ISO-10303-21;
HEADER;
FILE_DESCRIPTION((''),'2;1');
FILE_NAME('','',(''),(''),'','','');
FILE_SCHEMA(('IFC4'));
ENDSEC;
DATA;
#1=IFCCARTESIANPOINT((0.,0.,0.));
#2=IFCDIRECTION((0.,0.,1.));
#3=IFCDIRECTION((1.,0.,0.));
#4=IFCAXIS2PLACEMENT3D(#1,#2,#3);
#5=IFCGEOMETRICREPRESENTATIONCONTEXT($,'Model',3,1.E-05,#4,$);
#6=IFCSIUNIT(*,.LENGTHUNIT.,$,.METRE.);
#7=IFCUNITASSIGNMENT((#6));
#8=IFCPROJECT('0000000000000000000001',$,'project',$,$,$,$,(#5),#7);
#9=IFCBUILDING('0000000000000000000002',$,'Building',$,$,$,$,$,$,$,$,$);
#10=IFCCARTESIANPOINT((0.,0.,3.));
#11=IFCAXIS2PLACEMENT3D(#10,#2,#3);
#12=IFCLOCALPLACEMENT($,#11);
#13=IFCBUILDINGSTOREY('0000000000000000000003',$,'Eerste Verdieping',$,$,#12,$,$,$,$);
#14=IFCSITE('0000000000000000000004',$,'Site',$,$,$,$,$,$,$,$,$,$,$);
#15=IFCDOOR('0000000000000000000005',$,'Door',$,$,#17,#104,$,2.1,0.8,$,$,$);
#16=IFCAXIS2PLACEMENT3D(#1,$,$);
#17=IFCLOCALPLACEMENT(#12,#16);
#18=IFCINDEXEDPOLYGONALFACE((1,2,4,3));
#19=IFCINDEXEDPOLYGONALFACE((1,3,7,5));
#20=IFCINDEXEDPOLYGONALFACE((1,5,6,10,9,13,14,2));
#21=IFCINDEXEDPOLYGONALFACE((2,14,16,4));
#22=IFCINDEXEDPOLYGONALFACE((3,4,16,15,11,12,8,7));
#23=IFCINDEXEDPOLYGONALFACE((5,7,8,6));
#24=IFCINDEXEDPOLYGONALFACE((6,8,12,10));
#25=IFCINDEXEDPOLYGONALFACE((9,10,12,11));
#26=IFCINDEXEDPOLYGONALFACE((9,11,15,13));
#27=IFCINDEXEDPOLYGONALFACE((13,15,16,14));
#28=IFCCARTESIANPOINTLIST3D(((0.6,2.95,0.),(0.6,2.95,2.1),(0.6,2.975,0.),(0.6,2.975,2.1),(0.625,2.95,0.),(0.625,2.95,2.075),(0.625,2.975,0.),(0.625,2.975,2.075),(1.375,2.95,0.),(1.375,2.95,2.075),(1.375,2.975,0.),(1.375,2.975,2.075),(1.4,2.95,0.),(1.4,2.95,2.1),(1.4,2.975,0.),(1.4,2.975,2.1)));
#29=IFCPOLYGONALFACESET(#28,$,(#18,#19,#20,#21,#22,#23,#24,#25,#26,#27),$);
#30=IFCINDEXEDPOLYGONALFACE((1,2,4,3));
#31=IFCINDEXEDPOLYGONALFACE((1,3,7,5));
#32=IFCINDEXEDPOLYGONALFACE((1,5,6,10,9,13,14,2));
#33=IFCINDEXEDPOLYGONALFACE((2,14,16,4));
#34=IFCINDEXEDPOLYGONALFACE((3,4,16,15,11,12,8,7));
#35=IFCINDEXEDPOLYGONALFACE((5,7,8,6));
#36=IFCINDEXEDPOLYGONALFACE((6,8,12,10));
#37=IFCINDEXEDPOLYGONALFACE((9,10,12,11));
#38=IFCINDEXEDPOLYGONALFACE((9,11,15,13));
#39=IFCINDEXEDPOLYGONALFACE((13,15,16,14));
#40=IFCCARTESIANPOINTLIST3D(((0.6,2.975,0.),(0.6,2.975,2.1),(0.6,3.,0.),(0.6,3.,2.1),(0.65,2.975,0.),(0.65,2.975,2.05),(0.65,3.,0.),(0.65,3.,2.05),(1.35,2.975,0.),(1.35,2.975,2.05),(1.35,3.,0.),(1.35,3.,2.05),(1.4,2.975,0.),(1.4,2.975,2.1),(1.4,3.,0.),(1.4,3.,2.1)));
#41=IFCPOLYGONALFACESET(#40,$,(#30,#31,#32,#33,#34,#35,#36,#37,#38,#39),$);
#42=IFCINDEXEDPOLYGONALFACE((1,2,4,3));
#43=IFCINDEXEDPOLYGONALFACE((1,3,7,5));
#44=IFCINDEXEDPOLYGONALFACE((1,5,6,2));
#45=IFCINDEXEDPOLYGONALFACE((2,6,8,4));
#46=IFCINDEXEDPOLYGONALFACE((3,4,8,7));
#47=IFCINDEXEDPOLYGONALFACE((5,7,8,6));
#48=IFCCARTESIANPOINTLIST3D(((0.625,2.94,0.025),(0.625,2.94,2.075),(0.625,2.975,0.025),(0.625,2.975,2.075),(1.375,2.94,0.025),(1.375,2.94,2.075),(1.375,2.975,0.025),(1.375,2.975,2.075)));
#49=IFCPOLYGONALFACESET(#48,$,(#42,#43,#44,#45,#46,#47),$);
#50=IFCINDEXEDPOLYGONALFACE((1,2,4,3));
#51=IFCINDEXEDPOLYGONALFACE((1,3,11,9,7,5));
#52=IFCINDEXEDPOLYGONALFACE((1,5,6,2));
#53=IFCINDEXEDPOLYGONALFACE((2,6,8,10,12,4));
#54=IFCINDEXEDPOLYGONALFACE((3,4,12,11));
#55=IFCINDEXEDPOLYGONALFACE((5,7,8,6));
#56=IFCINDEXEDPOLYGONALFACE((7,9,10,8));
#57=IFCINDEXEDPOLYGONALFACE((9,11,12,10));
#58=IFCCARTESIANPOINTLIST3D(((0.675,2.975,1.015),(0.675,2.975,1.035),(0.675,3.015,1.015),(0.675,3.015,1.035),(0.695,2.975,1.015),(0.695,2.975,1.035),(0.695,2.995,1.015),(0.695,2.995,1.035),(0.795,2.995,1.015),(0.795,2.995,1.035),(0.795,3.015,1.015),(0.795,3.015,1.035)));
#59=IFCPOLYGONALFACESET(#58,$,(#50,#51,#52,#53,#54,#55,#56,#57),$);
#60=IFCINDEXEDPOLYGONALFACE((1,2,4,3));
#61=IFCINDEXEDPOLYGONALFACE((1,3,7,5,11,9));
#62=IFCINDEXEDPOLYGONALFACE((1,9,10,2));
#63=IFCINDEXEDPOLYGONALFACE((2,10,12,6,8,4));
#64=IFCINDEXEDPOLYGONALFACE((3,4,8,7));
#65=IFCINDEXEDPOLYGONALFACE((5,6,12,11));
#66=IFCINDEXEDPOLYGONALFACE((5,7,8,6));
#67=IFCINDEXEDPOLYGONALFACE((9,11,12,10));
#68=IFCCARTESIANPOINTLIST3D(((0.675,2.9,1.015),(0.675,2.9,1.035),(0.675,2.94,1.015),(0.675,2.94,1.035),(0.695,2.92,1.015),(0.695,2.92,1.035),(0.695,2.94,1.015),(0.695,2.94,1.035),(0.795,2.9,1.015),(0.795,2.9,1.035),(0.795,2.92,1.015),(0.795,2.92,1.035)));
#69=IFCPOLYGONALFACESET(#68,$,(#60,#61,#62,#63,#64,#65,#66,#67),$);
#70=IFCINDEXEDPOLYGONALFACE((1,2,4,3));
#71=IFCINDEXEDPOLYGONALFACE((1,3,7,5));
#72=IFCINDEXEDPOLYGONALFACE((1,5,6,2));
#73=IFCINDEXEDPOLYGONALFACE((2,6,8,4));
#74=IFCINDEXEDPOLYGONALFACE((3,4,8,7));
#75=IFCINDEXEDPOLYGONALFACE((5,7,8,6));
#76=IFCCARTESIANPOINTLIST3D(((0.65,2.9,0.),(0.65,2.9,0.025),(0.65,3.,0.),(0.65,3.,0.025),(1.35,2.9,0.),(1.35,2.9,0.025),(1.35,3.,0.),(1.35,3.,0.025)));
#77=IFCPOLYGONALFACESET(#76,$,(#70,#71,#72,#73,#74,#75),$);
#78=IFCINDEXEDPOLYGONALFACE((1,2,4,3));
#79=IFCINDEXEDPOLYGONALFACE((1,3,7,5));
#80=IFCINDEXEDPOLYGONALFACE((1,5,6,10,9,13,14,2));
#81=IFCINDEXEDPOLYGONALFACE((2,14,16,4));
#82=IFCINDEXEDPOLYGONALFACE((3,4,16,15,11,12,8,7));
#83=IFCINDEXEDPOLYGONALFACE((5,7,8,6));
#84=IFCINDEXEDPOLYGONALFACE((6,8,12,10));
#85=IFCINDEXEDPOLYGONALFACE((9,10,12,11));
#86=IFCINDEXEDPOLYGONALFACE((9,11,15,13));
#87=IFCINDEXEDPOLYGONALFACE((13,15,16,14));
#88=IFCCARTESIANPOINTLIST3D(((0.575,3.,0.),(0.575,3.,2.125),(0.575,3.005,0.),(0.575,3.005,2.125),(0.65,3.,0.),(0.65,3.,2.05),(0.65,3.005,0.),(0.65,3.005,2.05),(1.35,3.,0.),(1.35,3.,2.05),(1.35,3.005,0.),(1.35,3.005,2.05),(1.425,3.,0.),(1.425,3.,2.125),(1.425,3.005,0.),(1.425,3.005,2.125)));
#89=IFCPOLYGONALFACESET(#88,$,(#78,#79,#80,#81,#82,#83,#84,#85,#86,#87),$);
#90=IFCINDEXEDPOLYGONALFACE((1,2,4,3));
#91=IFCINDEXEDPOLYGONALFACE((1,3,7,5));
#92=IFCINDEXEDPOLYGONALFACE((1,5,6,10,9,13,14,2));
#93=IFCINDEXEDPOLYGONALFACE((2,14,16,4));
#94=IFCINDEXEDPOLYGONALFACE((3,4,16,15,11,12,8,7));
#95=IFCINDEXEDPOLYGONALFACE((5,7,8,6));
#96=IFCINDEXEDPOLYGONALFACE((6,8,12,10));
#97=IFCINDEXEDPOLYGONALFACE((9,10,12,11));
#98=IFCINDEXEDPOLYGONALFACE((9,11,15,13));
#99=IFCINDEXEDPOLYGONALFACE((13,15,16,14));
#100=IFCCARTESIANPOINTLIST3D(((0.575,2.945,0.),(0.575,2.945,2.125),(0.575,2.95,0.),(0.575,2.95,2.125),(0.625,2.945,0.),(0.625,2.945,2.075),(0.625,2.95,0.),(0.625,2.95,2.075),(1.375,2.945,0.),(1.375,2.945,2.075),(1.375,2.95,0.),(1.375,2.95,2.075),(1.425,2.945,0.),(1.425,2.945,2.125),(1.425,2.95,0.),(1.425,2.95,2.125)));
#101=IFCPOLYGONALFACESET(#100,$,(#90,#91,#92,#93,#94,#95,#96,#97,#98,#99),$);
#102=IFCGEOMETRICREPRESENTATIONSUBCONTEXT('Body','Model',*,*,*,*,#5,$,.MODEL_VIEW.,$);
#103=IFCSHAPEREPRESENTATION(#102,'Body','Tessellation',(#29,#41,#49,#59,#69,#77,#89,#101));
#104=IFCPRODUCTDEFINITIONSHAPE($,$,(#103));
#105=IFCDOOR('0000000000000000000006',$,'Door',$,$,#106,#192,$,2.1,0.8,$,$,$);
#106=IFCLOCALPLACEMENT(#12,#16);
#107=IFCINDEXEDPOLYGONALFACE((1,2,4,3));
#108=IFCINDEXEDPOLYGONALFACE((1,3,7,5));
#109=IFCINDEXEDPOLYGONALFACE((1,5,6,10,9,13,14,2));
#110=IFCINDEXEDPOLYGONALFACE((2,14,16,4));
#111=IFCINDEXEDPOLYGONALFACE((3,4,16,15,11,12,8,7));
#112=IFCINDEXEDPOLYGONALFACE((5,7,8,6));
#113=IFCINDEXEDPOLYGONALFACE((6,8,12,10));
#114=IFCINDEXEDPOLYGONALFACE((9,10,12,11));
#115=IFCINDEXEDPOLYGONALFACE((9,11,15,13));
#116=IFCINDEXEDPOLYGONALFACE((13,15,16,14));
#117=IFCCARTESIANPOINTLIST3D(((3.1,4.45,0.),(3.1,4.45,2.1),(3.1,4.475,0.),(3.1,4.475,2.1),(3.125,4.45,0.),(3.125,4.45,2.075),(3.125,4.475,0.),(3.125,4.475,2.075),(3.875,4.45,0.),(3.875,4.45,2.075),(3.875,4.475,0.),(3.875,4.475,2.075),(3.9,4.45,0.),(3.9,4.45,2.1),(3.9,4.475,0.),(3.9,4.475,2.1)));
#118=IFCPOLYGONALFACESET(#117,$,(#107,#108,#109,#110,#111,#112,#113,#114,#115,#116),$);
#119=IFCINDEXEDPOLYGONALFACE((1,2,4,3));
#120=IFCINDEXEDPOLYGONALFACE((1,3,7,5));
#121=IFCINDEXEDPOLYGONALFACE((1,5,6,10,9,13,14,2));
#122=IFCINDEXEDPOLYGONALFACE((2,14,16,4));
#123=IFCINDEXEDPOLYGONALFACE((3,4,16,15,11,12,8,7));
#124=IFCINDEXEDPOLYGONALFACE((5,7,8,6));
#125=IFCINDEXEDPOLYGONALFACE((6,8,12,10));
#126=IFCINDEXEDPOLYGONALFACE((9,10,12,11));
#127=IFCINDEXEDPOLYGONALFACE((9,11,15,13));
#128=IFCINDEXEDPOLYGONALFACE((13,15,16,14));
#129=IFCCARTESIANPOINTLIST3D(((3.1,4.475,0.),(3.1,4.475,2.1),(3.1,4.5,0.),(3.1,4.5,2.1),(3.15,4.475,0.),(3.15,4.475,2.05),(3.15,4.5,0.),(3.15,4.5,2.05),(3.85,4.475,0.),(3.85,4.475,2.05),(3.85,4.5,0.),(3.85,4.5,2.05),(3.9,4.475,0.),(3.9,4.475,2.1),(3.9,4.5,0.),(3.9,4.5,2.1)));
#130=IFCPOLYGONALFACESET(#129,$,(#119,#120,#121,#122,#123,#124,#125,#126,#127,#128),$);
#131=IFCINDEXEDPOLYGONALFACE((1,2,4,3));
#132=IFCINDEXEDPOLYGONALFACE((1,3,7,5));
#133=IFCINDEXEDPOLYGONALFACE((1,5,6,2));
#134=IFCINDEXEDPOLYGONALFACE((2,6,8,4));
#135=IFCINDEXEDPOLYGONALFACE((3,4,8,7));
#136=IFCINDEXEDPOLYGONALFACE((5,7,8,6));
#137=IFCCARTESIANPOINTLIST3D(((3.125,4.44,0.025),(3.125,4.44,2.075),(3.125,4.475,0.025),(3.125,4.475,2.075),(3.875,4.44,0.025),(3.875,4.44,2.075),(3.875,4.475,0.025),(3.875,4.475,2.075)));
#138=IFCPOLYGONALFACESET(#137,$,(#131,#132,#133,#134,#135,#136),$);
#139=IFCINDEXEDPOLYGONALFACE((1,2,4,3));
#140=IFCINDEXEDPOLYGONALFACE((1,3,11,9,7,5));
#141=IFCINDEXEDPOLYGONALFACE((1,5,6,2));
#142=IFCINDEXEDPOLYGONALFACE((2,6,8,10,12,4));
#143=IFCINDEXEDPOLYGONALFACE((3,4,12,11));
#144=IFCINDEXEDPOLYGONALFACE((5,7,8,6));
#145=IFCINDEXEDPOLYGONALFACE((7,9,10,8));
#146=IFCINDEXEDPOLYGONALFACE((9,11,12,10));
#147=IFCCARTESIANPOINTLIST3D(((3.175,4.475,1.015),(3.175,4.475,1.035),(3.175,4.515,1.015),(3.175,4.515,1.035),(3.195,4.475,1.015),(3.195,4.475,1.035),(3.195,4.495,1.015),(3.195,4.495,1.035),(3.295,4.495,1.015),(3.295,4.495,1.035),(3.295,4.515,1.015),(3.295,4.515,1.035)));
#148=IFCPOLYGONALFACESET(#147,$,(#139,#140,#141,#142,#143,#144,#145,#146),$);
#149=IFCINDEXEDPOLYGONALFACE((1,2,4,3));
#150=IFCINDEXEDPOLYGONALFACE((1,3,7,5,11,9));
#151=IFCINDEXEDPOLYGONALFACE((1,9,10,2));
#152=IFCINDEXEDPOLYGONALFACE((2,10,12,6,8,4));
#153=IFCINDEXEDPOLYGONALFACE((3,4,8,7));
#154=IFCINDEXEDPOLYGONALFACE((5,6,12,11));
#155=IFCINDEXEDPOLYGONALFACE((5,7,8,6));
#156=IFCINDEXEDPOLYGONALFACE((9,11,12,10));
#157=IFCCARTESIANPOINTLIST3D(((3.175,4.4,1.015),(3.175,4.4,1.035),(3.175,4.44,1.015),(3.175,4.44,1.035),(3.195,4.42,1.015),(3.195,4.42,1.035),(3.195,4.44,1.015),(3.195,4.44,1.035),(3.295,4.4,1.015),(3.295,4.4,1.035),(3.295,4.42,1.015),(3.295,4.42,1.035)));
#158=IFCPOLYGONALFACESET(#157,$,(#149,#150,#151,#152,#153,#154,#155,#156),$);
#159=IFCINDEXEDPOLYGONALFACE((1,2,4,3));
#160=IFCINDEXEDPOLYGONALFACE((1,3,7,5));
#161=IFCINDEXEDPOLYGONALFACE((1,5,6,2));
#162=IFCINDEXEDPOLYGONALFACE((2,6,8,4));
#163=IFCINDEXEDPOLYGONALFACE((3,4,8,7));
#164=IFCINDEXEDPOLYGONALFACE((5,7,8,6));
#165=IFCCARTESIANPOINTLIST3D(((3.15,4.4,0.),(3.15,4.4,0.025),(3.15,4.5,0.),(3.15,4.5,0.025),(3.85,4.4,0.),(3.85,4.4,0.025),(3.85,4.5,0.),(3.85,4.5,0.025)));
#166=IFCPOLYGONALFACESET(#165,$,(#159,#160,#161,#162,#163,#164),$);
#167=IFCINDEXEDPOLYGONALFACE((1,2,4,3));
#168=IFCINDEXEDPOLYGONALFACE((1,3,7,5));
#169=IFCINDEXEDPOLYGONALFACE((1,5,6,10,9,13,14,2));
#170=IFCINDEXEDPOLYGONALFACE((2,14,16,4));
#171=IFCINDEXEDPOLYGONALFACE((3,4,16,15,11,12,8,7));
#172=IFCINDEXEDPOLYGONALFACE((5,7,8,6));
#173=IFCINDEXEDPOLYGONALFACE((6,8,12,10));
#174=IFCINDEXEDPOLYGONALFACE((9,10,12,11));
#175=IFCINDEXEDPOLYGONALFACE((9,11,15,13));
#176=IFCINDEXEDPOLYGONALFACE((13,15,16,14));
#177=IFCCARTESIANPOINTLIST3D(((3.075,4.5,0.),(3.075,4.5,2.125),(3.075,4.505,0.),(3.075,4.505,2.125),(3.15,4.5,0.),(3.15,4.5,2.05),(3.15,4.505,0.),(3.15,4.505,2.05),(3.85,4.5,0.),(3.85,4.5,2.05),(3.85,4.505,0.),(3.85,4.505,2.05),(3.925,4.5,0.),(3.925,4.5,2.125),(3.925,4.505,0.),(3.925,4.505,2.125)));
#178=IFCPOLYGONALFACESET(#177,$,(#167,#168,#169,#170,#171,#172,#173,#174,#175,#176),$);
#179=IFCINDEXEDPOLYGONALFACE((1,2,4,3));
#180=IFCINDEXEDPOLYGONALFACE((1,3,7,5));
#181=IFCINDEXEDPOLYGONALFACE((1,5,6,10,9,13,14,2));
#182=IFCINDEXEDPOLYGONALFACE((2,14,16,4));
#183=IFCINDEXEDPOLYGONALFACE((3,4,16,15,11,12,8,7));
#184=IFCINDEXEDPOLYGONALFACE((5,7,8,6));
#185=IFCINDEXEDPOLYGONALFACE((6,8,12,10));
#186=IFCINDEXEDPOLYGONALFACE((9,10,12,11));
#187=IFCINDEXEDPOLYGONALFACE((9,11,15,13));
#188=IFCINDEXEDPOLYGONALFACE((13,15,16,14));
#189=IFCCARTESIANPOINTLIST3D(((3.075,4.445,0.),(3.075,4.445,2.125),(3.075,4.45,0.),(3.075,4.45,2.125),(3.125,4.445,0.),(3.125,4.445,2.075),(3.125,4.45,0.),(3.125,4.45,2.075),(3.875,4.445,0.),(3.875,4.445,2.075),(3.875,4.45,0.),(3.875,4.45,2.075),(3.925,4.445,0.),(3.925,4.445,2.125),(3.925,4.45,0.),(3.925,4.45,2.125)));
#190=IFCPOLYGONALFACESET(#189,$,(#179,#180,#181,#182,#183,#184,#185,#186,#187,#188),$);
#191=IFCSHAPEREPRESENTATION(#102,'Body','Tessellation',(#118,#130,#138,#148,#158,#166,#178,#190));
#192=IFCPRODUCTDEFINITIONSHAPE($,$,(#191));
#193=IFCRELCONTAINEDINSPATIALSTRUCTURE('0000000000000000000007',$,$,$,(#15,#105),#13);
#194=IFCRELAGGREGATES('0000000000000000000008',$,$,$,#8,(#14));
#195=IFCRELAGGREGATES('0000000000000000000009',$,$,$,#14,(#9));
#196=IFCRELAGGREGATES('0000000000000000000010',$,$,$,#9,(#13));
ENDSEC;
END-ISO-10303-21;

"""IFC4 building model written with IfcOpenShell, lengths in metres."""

from ifc_helpers import new_model, si_unit, frame, origin_with_axes, place, context, subcontext, project, spatial, line, indexed_curve, outline, extrude, element, save


model = new_model("IFC4")

# Units and contexts
model_context = context("Model", 3, precision=1e-05, world=origin_with_axes())
body_context = subcontext(model_context, "Body", "Model", "MODEL_VIEW")
ifc_project = project(units=[si_unit("LENGTHUNIT", "METRE")], contexts=[model_context])

# Site, building, storey
site = spatial("IfcSite", under=ifc_project, Name="Site")
building = spatial("IfcBuilding", under=site, Name="Building")
storey_placement = place(None, frame((0.0, 0.0, 3.0), z_axis=(0.0, 0.0, 1.0), x_axis=(1.0, 0.0, 0.0)))
storey = spatial("IfcBuildingStorey", under=building, at=storey_placement, Name="Eerste Verdieping")

# Doors
door_1_placement = place(storey_placement, frame((1.4, 3.0, 0.0), z_axis=(0.0, 0.0, 1.0), x_axis=(-1.0, 0.0, 0.0)))
element("IfcDoor", 1, at=door_1_placement, inside=storey, Name="Door", OverallHeight=2.1, OverallWidth=0.8, context=body_context, shape_type="SweptSolid", body=[
    extrude(outline(indexed_curve([(0.0, 0.0), (0.0, 2.1), (0.8, 2.1), (0.8, 0.0), (0.775, 0.0), (0.775, 2.075), (0.025, 2.075), (0.025, 0.0)], segments=[line(1, 2, 3, 4, 5, 6, 7, 8, 1)])), frame((0.0, 0.025, 0.0), z_axis=(0.0, -1.0, 0.0), x_axis=(1.0, 0.0, 0.0)), (0.0, 0.0, -1.0), 0.025),
    extrude(outline(indexed_curve([(0.0, 0.0), (0.0, 2.1), (0.8, 2.1), (0.8, 0.0), (0.75, 0.0), (0.75, 2.05), (0.05, 2.05), (0.05, 0.0)], segments=[line(1, 2, 3, 4, 5, 6, 7, 8, 1)])), frame((0.0, 0.0, 0.0), z_axis=(0.0, -1.0, 0.0), x_axis=(1.0, 0.0, 0.0)), (0.0, 0.0, -1.0), 0.025),
    extrude(outline(indexed_curve([(0.0, 0.0), (0.75, 0.0), (0.75, 0.035), (0.0, 0.035)], segments=[line(1, 2, 3, 4, 1)])), frame((0.025, 0.025, 0.025), z_axis=(0.0, 0.0, 1.0), x_axis=(1.0, 0.0, 0.0)), (0.0, 0.0, 1.0), 2.05),
    extrude(outline(indexed_curve([(0.0, 0.0), (0.0, -0.04), (-0.12, -0.04), (-0.12, -0.02), (-0.02, -0.02), (-0.02, 0.0)], segments=[line(1, 2, 3, 4, 5, 6, 1)])), frame((0.725, 0.025, 1.015), z_axis=(0.0, 0.0, 1.0), x_axis=(1.0, 0.0, 0.0)), (0.0, 0.0, 1.0), 0.02),
    extrude(outline(indexed_curve([(0.0, 0.0), (0.0, 0.04), (-0.12, 0.04), (-0.12, 0.02), (-0.02, 0.02), (-0.02, 0.0)], segments=[line(1, 2, 3, 4, 5, 6, 1)])), frame((0.725, 0.06, 1.015), z_axis=(0.0, 0.0, 1.0), x_axis=(1.0, 0.0, 0.0)), (0.0, 0.0, 1.0), 0.02),
    extrude(outline(indexed_curve([(0.0, 0.0), (0.7, 0.0), (0.7, 0.1), (0.0, 0.1)], segments=[line(1, 2, 3, 4, 1)])), frame((0.05, 0.0, 0.0), z_axis=(0.0, 0.0, 1.0), x_axis=(1.0, 0.0, 0.0)), (0.0, 0.0, 1.0), 0.025),
    extrude(outline(indexed_curve([(0.0, 0.0), (0.0, 2.125), (0.85, 2.125), (0.85, 0.0), (0.775, 0.0), (0.775, 2.05), (0.075, 2.05), (0.075, 0.0)], segments=[line(1, 2, 3, 4, 5, 6, 7, 8, 1)])), frame((-0.025, -0.005, 0.0), z_axis=(0.0, -1.0, 0.0), x_axis=(1.0, 0.0, 0.0)), (0.0, 0.0, -1.0), 0.005),
    extrude(outline(indexed_curve([(0.0, 0.0), (0.0, 2.125), (0.85, 2.125), (0.85, 0.0), (0.8, 0.0), (0.8, 2.075), (0.05, 2.075), (0.05, 0.0)], segments=[line(1, 2, 3, 4, 5, 6, 7, 8, 1)])), frame((-0.025, 0.05, 0.0), z_axis=(0.0, -1.0, 0.0), x_axis=(1.0, 0.0, 0.0)), (0.0, 0.0, -1.0), 0.005),
])
door_2_placement = place(storey_placement, frame((3.9, 4.5, 0.0), z_axis=(0.0, 0.0, 1.0), x_axis=(-1.0, 0.0, 0.0)))
element("IfcDoor", 2, at=door_2_placement, inside=storey, Name="Door", OverallHeight=2.1, OverallWidth=0.8, context=body_context, shape_type="SweptSolid", body=[
    extrude(outline(indexed_curve([(0.0, 0.0), (0.0, 2.1), (0.8, 2.1), (0.8, 0.0), (0.775, 0.0), (0.775, 2.075), (0.025, 2.075), (0.025, 0.0)], segments=[line(1, 2, 3, 4, 5, 6, 7, 8, 1)])), frame((0.0, 0.025, 0.0), z_axis=(0.0, -1.0, 0.0), x_axis=(1.0, 0.0, 0.0)), (0.0, 0.0, -1.0), 0.025),
    extrude(outline(indexed_curve([(0.0, 0.0), (0.0, 2.1), (0.8, 2.1), (0.8, 0.0), (0.75, 0.0), (0.75, 2.05), (0.05, 2.05), (0.05, 0.0)], segments=[line(1, 2, 3, 4, 5, 6, 7, 8, 1)])), frame((0.0, 0.0, 0.0), z_axis=(0.0, -1.0, 0.0), x_axis=(1.0, 0.0, 0.0)), (0.0, 0.0, -1.0), 0.025),
    extrude(outline(indexed_curve([(0.0, 0.0), (0.75, 0.0), (0.75, 0.035), (0.0, 0.035)], segments=[line(1, 2, 3, 4, 1)])), frame((0.025, 0.025, 0.025), z_axis=(0.0, 0.0, 1.0), x_axis=(1.0, 0.0, 0.0)), (0.0, 0.0, 1.0), 2.05),
    extrude(outline(indexed_curve([(0.0, 0.0), (0.0, -0.04), (-0.12, -0.04), (-0.12, -0.02), (-0.02, -0.02), (-0.02, 0.0)], segments=[line(1, 2, 3, 4, 5, 6, 1)])), frame((0.725, 0.025, 1.015), z_axis=(0.0, 0.0, 1.0), x_axis=(1.0, 0.0, 0.0)), (0.0, 0.0, 1.0), 0.02),
    extrude(outline(indexed_curve([(0.0, 0.0), (0.0, 0.04), (-0.12, 0.04), (-0.12, 0.02), (-0.02, 0.02), (-0.02, 0.0)], segments=[line(1, 2, 3, 4, 5, 6, 1)])), frame((0.725, 0.06, 1.015), z_axis=(0.0, 0.0, 1.0), x_axis=(1.0, 0.0, 0.0)), (0.0, 0.0, 1.0), 0.02),
    extrude(outline(indexed_curve([(0.0, 0.0), (0.7, 0.0), (0.7, 0.1), (0.0, 0.1)], segments=[line(1, 2, 3, 4, 1)])), frame((0.05, 0.0, 0.0), z_axis=(0.0, 0.0, 1.0), x_axis=(1.0, 0.0, 0.0)), (0.0, 0.0, 1.0), 0.025),
    extrude(outline(indexed_curve([(0.0, 0.0), (0.0, 2.125), (0.85, 2.125), (0.85, 0.0), (0.775, 0.0), (0.775, 2.05), (0.075, 2.05), (0.075, 0.0)], segments=[line(1, 2, 3, 4, 5, 6, 7, 8, 1)])), frame((-0.025, -0.005, 0.0), z_axis=(0.0, -1.0, 0.0), x_axis=(1.0, 0.0, 0.0)), (0.0, 0.0, -1.0), 0.005),
    extrude(outline(indexed_curve([(0.0, 0.0), (0.0, 2.125), (0.85, 2.125), (0.85, 0.0), (0.8, 0.0), (0.8, 2.075), (0.05, 2.075), (0.05, 0.0)], segments=[line(1, 2, 3, 4, 5, 6, 7, 8, 1)])), frame((-0.025, 0.05, 0.0), z_axis=(0.0, -1.0, 0.0), x_axis=(1.0, 0.0, 0.0)), (0.0, 0.0, -1.0), 0.005),
])

save(model, "model.ifc")
